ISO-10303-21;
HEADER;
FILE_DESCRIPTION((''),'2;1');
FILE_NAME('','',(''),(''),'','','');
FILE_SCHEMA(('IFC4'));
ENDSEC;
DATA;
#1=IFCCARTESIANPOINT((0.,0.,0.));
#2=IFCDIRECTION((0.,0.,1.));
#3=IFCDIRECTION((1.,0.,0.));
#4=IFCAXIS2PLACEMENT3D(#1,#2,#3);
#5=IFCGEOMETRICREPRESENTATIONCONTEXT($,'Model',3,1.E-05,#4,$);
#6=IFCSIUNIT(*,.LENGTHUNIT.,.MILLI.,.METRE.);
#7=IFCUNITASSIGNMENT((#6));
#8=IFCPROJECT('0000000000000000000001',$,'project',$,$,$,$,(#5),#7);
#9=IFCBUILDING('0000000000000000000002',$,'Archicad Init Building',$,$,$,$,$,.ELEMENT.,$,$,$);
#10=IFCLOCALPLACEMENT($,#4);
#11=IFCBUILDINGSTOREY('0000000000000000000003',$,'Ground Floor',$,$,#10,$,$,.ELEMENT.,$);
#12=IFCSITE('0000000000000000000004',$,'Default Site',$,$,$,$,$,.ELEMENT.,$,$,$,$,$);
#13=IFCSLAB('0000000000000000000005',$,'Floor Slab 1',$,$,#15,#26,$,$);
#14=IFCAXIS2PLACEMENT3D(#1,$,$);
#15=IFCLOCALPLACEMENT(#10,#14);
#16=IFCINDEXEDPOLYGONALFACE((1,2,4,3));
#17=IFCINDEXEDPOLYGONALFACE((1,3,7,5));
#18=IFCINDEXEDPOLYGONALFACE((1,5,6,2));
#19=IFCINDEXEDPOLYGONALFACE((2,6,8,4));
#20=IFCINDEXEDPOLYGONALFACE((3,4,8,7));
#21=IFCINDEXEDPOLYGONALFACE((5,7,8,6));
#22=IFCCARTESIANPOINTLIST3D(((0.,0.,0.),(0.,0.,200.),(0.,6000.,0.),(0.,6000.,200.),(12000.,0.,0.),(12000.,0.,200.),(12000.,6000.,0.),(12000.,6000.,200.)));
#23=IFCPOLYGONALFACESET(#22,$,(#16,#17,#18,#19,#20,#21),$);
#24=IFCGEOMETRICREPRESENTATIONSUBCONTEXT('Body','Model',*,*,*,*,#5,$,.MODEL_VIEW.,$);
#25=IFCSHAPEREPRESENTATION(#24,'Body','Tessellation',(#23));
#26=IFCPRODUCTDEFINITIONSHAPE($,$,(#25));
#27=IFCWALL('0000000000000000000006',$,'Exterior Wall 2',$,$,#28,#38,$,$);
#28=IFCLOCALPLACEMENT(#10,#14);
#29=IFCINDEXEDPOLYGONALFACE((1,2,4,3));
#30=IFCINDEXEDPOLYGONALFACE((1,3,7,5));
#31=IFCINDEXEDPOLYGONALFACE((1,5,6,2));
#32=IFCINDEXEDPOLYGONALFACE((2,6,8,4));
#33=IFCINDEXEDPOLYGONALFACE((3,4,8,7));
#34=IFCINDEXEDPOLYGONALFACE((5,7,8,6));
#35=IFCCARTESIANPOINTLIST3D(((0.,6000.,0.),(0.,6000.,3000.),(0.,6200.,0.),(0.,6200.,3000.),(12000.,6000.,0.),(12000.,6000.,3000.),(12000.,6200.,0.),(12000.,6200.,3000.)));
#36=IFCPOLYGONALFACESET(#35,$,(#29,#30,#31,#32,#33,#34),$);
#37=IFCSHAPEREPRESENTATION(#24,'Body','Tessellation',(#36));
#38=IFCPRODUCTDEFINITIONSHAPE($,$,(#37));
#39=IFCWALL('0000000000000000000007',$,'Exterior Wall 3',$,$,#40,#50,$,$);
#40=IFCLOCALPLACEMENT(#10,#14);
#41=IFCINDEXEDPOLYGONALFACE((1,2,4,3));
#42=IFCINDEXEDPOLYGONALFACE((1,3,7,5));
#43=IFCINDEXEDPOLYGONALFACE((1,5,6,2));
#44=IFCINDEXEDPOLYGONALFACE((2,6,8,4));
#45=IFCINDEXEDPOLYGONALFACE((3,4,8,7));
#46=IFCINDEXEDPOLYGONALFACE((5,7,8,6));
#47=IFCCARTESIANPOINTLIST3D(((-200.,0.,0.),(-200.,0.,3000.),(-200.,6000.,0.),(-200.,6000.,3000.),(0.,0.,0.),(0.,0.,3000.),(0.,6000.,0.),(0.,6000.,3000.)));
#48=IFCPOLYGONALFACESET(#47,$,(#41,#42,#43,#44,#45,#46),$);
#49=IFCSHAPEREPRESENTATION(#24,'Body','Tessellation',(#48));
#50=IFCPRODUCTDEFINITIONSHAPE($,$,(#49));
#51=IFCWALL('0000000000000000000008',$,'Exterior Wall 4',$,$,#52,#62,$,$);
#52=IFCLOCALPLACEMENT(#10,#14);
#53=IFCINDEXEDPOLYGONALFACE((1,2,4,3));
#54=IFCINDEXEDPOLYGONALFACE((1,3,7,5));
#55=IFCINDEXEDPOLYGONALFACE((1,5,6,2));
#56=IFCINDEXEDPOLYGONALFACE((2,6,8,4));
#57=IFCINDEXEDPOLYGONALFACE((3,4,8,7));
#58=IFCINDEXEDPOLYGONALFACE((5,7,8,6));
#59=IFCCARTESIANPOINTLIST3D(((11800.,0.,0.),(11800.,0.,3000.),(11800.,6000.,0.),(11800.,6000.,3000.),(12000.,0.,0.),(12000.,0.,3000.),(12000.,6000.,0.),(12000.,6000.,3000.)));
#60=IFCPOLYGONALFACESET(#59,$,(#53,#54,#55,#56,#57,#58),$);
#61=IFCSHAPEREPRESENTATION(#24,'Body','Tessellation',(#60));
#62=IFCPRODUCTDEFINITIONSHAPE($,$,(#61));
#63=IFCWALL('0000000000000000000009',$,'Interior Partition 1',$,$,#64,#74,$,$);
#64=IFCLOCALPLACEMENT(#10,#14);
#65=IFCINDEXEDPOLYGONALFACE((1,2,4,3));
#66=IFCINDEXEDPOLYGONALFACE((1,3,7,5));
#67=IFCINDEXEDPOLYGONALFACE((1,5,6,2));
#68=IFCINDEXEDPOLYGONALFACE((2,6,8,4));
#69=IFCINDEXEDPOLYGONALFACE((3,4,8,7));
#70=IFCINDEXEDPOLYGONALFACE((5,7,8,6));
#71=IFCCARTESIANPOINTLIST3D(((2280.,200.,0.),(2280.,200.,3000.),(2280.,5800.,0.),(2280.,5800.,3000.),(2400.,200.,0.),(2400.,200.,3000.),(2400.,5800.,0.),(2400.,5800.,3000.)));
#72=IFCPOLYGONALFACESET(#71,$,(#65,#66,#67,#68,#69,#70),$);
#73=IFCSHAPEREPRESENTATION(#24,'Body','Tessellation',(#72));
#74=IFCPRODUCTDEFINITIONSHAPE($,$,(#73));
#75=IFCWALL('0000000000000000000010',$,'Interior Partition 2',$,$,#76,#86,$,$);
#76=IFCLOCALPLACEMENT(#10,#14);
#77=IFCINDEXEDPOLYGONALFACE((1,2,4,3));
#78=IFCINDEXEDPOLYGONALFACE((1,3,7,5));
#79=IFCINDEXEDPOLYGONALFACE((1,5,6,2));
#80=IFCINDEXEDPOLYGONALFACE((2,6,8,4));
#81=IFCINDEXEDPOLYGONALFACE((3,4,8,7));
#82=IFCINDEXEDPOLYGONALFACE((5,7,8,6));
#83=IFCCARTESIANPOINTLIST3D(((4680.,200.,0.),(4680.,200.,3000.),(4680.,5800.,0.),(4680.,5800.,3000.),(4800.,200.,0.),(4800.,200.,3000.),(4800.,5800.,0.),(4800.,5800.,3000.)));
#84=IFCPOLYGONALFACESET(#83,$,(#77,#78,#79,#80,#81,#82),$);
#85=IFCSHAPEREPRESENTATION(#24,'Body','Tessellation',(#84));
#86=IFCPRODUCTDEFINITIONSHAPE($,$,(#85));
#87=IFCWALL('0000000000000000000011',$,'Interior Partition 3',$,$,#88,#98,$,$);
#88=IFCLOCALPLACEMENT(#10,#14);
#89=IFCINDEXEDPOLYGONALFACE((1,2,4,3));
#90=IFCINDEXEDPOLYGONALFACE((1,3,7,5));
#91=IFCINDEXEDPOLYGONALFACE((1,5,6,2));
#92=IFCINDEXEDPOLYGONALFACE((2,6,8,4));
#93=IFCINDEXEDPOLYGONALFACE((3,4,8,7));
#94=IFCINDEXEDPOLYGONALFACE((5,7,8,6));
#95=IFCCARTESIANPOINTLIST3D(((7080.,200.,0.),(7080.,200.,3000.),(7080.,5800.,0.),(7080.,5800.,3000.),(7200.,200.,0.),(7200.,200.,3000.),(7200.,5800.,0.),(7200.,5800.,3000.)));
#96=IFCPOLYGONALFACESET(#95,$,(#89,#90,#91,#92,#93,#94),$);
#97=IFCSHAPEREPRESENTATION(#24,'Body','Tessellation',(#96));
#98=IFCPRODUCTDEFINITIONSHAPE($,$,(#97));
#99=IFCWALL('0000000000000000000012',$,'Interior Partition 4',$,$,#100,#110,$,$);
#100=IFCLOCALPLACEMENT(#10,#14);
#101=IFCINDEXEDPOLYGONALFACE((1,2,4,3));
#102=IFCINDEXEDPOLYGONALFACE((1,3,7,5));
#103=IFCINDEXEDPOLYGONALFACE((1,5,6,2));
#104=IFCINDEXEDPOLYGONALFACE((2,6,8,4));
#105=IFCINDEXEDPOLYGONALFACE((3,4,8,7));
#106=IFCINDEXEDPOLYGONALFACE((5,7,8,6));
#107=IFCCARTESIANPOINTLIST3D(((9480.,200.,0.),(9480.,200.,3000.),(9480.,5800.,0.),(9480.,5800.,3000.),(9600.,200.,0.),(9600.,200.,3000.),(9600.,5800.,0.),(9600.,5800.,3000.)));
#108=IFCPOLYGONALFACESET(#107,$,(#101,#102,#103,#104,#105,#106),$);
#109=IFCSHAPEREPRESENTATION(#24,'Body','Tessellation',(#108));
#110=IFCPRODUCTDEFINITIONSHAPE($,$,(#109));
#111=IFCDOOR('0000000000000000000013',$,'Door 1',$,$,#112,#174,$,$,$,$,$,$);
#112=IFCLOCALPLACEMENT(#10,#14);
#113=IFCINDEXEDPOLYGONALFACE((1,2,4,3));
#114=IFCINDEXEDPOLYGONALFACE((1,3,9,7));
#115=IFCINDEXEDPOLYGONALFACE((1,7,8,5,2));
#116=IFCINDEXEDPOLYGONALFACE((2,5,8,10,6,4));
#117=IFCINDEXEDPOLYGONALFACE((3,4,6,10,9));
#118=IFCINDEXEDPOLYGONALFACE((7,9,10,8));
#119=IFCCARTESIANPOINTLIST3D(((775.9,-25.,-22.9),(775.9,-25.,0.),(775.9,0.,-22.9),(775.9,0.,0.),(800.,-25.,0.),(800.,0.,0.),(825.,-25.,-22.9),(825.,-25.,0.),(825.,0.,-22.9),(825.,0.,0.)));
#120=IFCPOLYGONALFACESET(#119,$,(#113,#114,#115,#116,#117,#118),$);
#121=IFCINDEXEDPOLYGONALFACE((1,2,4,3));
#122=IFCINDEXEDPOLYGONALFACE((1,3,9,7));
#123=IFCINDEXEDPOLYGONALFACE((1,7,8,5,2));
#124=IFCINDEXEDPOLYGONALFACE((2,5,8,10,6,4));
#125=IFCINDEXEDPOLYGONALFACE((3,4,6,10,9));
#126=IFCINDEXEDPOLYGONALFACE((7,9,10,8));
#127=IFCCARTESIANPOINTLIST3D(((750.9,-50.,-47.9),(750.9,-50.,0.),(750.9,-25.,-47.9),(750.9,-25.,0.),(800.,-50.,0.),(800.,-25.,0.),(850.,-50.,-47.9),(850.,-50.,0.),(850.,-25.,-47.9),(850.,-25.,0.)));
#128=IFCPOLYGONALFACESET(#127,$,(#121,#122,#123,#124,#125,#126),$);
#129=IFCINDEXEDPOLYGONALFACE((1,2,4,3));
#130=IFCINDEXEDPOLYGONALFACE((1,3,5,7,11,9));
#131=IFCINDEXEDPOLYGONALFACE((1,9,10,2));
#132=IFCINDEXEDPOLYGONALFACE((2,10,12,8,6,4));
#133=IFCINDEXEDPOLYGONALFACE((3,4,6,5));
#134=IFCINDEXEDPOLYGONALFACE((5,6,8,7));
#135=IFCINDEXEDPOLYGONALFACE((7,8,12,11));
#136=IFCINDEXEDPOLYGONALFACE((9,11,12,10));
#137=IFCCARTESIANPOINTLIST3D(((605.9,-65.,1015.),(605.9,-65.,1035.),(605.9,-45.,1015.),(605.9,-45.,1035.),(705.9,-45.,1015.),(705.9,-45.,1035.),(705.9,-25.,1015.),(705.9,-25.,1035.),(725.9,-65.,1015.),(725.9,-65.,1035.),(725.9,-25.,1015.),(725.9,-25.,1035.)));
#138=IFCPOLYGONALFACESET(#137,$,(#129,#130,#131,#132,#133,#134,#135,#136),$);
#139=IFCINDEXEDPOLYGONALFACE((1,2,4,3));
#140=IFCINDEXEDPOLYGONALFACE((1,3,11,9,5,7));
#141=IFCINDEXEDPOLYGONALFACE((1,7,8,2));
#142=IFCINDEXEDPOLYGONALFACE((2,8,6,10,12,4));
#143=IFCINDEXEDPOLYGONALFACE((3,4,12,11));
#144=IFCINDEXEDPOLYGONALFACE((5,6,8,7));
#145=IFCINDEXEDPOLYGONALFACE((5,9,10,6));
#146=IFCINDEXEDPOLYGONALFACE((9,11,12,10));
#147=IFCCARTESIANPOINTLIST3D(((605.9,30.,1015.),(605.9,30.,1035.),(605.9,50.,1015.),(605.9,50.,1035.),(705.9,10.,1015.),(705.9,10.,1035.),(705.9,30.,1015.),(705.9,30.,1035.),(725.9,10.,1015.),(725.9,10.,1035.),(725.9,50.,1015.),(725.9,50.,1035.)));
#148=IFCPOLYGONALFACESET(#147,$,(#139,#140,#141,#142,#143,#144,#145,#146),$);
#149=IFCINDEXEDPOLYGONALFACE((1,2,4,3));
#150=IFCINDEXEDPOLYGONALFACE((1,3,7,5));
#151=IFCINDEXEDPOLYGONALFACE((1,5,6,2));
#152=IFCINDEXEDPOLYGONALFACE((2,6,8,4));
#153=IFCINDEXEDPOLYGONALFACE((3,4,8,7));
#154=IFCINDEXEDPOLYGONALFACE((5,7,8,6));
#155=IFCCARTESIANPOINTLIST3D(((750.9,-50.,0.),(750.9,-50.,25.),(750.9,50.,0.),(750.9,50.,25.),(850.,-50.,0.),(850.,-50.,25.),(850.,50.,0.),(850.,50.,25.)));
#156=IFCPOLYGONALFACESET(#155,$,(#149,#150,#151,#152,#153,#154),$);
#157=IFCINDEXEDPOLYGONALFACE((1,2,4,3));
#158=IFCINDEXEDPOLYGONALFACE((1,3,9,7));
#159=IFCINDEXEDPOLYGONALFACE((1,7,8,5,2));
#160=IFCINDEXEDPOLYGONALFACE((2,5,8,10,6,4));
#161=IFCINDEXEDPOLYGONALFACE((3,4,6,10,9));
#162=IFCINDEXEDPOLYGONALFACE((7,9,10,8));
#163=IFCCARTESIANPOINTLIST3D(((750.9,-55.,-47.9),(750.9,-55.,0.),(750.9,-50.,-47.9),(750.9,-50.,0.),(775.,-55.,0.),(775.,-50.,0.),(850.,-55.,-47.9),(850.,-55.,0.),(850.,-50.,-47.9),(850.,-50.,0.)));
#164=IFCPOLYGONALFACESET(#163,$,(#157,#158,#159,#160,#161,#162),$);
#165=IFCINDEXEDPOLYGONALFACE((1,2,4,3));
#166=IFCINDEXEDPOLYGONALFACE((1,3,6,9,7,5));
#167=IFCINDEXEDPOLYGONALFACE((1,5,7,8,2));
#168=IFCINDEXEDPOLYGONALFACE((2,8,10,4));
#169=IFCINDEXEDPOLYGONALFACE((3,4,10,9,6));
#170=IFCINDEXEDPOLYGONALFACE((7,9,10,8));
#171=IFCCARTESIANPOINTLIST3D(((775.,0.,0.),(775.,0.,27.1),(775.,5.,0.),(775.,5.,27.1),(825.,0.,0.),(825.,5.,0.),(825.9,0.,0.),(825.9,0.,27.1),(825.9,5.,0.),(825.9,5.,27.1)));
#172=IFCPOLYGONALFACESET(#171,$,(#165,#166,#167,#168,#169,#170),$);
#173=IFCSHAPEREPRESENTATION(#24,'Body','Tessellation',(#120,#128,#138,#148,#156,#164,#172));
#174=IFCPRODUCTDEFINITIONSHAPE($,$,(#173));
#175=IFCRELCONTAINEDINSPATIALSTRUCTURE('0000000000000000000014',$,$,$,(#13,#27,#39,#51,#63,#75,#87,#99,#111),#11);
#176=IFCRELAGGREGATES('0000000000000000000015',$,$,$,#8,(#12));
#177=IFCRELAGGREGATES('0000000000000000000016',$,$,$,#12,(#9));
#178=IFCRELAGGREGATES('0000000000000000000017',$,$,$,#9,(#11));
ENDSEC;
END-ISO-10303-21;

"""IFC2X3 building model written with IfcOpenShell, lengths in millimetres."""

from ifc_helpers import new_model, si_unit, frame, origin_with_axes, place, context, subcontext, project, spatial, polyline, outline, extrude, element, save


model = new_model("IFC2X3")

# Units and contexts
model_context = context("Model", 3, precision=1e-05, world=origin_with_axes())
body_context = subcontext(model_context, "Body", "Model", "MODEL_VIEW")
ifc_project = project(units=[si_unit("LENGTHUNIT", "METRE", prefix="MILLI")], contexts=[model_context])

# Site, building, storey
site = spatial("IfcSite", under=ifc_project, Name="Default Site", CompositionType="ELEMENT")
building = spatial("IfcBuilding", under=site, Name="Archicad Init Building", CompositionType="ELEMENT")
storey_placement = place(None, origin_with_axes())
storey = spatial("IfcBuildingStorey", under=building, at=storey_placement, Name="Ground Floor", CompositionType="ELEMENT")

# Slab
slab_placement = place(storey_placement, origin_with_axes())
element("IfcSlab", 1, at=slab_placement, inside=storey, Name="Floor Slab 1", context=body_context, shape_type="SweptSolid", body=[
    extrude(outline(polyline([(0.0, 0.0), (12000.0, 0.0), (12000.0, 6000.0), (0.0, 6000.0), (0.0, 0.0)])), origin_with_axes(), (0.0, 0.0, 1.0), 200.0),
])

# Walls
wall_placement = place(storey_placement, frame((0.0, 6000.0, 0.0), z_axis=(0.0, 0.0, 1.0), x_axis=(1.0, 0.0, 0.0)))
element("IfcWall", 2, at=wall_placement, inside=storey, Name="Exterior Wall 2", context=body_context, shape_type="SweptSolid", body=[
    extrude(outline(polyline([(0.0, 0.0), (0.0, 200.0), (12000.0, 200.0), (12000.0, 0.0), (0.0, 0.0)])), origin_with_axes(), (0.0, 0.0, 1.0), 3000.0),
])
for number, where, z_axis, x_axis, name in (
    (3, (0.0, 0.0, 0.0), (0.0, 0.0, 1.0), (0.0, 1.0, 0.0), "Exterior Wall 3"),
    (4, (12000.0, 0.0, 0.0), (0.0, 0.0, 1.0), (0.0, 1.0, 0.0), "Exterior Wall 4"),
):
    element("IfcWall", number, at=place(storey_placement, frame(where, z_axis=z_axis, x_axis=x_axis)), inside=storey, Name=name, context=body_context, shape_type="SweptSolid", body=[
        extrude(outline(polyline([(0.0, 0.0), (0.0, 200.0), (6000.0, 200.0), (6000.0, 0.0), (0.0, 0.0)])), origin_with_axes(), (0.0, 0.0, 1.0), 3000.0),
    ])
for number, where, z_axis, x_axis, name in (
    (5, (2400.0, 200.0, 0.0), (0.0, 0.0, 1.0), (0.0, 1.0, 0.0), "Interior Partition 1"),
    (6, (4800.0, 200.0, 0.0), (0.0, 0.0, 1.0), (0.0, 1.0, 0.0), "Interior Partition 2"),
    (7, (7200.0, 200.0, 0.0), (0.0, 0.0, 1.0), (0.0, 1.0, 0.0), "Interior Partition 3"),
    (8, (9600.0, 200.0, 0.0), (0.0, 0.0, 1.0), (0.0, 1.0, 0.0), "Interior Partition 4"),
):
    element("IfcWall", number, at=place(storey_placement, frame(where, z_axis=z_axis, x_axis=x_axis)), inside=storey, Name=name, context=body_context, shape_type="SweptSolid", body=[
        extrude(outline(polyline([(0.0, 0.0), (0.0, 120.0), (5600.0, 120.0), (5600.0, 0.0), (0.0, 0.0)])), origin_with_axes(), (0.0, 0.0, 1.0), 3000.0),
    ])

# Door
door_1_placement = place(storey_placement, frame((800.0, -50.0, 0.0), z_axis=(0.0, 0.0, 1.0), x_axis=(1.0, 0.0, 0.0)))
element("IfcDoor", 9, at=door_1_placement, inside=storey, Name="Door 1", context=body_context, shape_type="SweptSolid", body=[
    extrude(outline(polyline([(0.0, 0.0), (0.0, 2.1), (0.9, 2.1), (0.9, 0.0), (-24.1, 0.0), (-24.1, -22.9), (25.0, -22.9), (25.0, 0.0), (0.0, 0.0)])), frame((0.0, 25.0, 0.0), z_axis=(0.0, -1.0, 0.0), x_axis=(1.0, 0.0, 0.0)), (0.0, 0.0, -1.0), 25.0),
    extrude(outline(polyline([(0.0, 0.0), (0.0, 2.1), (0.9, 2.1), (0.9, 0.0), (-49.1, 0.0), (-49.1, -47.9), (50.0, -47.9), (50.0, 0.0), (0.0, 0.0)])), frame((0.0, 0.0, 0.0), z_axis=(0.0, -1.0, 0.0), x_axis=(1.0, 0.0, 0.0)), (0.0, 0.0, -1.0), 25.0),
    extrude(outline(polyline([(0.0, 0.0), (-49.1, 0.0), (-49.1, 35.0), (0.0, 35.0), (0.0, 0.0)])), frame((25.0, 25.0, 25.0), z_axis=(0.0, 0.0, 1.0), x_axis=(1.0, 0.0, 0.0)), (0.0, 0.0, 1.0), -47.9),
    extrude(outline(polyline([(0.0, 0.0), (0.0, -40.0), (-120.0, -40.0), (-120.0, -20.0), (-20.0, -20.0), (-20.0, 0.0), (0.0, 0.0)])), frame((-74.1, 25.0, 1015.0), z_axis=(0.0, 0.0, 1.0), x_axis=(1.0, 0.0, 0.0)), (0.0, 0.0, 1.0), 20.0),
    extrude(outline(polyline([(0.0, 0.0), (0.0, 40.0), (-120.0, 40.0), (-120.0, 20.0), (-20.0, 20.0), (-20.0, 0.0), (0.0, 0.0)])), frame((-74.1, 60.0, 1015.0), z_axis=(0.0, 0.0, 1.0), x_axis=(1.0, 0.0, 0.0)), (0.0, 0.0, 1.0), 20.0),
    extrude(outline(polyline([(0.0, 0.0), (-99.1, 0.0), (-99.1, 100.0), (0.0, 100.0), (0.0, 0.0)])), frame((50.0, 0.0, 0.0), z_axis=(0.0, 0.0, 1.0), x_axis=(1.0, 0.0, 0.0)), (0.0, 0.0, 1.0), 25.0),
    extrude(outline(polyline([(0.0, 0.0), (0.0, 27.1), (50.9, 27.1), (50.9, 0.0), (-24.1, 0.0), (-24.1, -47.9), (75.0, -47.9), (75.0, 0.0), (0.0, 0.0)])), frame((-25.0, -5.0, 0.0), z_axis=(0.0, -1.0, 0.0), x_axis=(1.0, 0.0, 0.0)), (0.0, 0.0, -1.0), 5.0),
    extrude(outline(polyline([(0.0, 0.0), (0.0, 27.1), (50.9, 27.1), (50.9, 0.0), (0.9, 0.0), (0.9, -22.9), (50.0, -22.9), (50.0, 0.0), (0.0, 0.0)])), frame((-25.0, 50.0, 0.0), z_axis=(0.0, -1.0, 0.0), x_axis=(1.0, 0.0, 0.0)), (0.0, 0.0, -1.0), 5.0),
])

save(model, "model.ifc")
